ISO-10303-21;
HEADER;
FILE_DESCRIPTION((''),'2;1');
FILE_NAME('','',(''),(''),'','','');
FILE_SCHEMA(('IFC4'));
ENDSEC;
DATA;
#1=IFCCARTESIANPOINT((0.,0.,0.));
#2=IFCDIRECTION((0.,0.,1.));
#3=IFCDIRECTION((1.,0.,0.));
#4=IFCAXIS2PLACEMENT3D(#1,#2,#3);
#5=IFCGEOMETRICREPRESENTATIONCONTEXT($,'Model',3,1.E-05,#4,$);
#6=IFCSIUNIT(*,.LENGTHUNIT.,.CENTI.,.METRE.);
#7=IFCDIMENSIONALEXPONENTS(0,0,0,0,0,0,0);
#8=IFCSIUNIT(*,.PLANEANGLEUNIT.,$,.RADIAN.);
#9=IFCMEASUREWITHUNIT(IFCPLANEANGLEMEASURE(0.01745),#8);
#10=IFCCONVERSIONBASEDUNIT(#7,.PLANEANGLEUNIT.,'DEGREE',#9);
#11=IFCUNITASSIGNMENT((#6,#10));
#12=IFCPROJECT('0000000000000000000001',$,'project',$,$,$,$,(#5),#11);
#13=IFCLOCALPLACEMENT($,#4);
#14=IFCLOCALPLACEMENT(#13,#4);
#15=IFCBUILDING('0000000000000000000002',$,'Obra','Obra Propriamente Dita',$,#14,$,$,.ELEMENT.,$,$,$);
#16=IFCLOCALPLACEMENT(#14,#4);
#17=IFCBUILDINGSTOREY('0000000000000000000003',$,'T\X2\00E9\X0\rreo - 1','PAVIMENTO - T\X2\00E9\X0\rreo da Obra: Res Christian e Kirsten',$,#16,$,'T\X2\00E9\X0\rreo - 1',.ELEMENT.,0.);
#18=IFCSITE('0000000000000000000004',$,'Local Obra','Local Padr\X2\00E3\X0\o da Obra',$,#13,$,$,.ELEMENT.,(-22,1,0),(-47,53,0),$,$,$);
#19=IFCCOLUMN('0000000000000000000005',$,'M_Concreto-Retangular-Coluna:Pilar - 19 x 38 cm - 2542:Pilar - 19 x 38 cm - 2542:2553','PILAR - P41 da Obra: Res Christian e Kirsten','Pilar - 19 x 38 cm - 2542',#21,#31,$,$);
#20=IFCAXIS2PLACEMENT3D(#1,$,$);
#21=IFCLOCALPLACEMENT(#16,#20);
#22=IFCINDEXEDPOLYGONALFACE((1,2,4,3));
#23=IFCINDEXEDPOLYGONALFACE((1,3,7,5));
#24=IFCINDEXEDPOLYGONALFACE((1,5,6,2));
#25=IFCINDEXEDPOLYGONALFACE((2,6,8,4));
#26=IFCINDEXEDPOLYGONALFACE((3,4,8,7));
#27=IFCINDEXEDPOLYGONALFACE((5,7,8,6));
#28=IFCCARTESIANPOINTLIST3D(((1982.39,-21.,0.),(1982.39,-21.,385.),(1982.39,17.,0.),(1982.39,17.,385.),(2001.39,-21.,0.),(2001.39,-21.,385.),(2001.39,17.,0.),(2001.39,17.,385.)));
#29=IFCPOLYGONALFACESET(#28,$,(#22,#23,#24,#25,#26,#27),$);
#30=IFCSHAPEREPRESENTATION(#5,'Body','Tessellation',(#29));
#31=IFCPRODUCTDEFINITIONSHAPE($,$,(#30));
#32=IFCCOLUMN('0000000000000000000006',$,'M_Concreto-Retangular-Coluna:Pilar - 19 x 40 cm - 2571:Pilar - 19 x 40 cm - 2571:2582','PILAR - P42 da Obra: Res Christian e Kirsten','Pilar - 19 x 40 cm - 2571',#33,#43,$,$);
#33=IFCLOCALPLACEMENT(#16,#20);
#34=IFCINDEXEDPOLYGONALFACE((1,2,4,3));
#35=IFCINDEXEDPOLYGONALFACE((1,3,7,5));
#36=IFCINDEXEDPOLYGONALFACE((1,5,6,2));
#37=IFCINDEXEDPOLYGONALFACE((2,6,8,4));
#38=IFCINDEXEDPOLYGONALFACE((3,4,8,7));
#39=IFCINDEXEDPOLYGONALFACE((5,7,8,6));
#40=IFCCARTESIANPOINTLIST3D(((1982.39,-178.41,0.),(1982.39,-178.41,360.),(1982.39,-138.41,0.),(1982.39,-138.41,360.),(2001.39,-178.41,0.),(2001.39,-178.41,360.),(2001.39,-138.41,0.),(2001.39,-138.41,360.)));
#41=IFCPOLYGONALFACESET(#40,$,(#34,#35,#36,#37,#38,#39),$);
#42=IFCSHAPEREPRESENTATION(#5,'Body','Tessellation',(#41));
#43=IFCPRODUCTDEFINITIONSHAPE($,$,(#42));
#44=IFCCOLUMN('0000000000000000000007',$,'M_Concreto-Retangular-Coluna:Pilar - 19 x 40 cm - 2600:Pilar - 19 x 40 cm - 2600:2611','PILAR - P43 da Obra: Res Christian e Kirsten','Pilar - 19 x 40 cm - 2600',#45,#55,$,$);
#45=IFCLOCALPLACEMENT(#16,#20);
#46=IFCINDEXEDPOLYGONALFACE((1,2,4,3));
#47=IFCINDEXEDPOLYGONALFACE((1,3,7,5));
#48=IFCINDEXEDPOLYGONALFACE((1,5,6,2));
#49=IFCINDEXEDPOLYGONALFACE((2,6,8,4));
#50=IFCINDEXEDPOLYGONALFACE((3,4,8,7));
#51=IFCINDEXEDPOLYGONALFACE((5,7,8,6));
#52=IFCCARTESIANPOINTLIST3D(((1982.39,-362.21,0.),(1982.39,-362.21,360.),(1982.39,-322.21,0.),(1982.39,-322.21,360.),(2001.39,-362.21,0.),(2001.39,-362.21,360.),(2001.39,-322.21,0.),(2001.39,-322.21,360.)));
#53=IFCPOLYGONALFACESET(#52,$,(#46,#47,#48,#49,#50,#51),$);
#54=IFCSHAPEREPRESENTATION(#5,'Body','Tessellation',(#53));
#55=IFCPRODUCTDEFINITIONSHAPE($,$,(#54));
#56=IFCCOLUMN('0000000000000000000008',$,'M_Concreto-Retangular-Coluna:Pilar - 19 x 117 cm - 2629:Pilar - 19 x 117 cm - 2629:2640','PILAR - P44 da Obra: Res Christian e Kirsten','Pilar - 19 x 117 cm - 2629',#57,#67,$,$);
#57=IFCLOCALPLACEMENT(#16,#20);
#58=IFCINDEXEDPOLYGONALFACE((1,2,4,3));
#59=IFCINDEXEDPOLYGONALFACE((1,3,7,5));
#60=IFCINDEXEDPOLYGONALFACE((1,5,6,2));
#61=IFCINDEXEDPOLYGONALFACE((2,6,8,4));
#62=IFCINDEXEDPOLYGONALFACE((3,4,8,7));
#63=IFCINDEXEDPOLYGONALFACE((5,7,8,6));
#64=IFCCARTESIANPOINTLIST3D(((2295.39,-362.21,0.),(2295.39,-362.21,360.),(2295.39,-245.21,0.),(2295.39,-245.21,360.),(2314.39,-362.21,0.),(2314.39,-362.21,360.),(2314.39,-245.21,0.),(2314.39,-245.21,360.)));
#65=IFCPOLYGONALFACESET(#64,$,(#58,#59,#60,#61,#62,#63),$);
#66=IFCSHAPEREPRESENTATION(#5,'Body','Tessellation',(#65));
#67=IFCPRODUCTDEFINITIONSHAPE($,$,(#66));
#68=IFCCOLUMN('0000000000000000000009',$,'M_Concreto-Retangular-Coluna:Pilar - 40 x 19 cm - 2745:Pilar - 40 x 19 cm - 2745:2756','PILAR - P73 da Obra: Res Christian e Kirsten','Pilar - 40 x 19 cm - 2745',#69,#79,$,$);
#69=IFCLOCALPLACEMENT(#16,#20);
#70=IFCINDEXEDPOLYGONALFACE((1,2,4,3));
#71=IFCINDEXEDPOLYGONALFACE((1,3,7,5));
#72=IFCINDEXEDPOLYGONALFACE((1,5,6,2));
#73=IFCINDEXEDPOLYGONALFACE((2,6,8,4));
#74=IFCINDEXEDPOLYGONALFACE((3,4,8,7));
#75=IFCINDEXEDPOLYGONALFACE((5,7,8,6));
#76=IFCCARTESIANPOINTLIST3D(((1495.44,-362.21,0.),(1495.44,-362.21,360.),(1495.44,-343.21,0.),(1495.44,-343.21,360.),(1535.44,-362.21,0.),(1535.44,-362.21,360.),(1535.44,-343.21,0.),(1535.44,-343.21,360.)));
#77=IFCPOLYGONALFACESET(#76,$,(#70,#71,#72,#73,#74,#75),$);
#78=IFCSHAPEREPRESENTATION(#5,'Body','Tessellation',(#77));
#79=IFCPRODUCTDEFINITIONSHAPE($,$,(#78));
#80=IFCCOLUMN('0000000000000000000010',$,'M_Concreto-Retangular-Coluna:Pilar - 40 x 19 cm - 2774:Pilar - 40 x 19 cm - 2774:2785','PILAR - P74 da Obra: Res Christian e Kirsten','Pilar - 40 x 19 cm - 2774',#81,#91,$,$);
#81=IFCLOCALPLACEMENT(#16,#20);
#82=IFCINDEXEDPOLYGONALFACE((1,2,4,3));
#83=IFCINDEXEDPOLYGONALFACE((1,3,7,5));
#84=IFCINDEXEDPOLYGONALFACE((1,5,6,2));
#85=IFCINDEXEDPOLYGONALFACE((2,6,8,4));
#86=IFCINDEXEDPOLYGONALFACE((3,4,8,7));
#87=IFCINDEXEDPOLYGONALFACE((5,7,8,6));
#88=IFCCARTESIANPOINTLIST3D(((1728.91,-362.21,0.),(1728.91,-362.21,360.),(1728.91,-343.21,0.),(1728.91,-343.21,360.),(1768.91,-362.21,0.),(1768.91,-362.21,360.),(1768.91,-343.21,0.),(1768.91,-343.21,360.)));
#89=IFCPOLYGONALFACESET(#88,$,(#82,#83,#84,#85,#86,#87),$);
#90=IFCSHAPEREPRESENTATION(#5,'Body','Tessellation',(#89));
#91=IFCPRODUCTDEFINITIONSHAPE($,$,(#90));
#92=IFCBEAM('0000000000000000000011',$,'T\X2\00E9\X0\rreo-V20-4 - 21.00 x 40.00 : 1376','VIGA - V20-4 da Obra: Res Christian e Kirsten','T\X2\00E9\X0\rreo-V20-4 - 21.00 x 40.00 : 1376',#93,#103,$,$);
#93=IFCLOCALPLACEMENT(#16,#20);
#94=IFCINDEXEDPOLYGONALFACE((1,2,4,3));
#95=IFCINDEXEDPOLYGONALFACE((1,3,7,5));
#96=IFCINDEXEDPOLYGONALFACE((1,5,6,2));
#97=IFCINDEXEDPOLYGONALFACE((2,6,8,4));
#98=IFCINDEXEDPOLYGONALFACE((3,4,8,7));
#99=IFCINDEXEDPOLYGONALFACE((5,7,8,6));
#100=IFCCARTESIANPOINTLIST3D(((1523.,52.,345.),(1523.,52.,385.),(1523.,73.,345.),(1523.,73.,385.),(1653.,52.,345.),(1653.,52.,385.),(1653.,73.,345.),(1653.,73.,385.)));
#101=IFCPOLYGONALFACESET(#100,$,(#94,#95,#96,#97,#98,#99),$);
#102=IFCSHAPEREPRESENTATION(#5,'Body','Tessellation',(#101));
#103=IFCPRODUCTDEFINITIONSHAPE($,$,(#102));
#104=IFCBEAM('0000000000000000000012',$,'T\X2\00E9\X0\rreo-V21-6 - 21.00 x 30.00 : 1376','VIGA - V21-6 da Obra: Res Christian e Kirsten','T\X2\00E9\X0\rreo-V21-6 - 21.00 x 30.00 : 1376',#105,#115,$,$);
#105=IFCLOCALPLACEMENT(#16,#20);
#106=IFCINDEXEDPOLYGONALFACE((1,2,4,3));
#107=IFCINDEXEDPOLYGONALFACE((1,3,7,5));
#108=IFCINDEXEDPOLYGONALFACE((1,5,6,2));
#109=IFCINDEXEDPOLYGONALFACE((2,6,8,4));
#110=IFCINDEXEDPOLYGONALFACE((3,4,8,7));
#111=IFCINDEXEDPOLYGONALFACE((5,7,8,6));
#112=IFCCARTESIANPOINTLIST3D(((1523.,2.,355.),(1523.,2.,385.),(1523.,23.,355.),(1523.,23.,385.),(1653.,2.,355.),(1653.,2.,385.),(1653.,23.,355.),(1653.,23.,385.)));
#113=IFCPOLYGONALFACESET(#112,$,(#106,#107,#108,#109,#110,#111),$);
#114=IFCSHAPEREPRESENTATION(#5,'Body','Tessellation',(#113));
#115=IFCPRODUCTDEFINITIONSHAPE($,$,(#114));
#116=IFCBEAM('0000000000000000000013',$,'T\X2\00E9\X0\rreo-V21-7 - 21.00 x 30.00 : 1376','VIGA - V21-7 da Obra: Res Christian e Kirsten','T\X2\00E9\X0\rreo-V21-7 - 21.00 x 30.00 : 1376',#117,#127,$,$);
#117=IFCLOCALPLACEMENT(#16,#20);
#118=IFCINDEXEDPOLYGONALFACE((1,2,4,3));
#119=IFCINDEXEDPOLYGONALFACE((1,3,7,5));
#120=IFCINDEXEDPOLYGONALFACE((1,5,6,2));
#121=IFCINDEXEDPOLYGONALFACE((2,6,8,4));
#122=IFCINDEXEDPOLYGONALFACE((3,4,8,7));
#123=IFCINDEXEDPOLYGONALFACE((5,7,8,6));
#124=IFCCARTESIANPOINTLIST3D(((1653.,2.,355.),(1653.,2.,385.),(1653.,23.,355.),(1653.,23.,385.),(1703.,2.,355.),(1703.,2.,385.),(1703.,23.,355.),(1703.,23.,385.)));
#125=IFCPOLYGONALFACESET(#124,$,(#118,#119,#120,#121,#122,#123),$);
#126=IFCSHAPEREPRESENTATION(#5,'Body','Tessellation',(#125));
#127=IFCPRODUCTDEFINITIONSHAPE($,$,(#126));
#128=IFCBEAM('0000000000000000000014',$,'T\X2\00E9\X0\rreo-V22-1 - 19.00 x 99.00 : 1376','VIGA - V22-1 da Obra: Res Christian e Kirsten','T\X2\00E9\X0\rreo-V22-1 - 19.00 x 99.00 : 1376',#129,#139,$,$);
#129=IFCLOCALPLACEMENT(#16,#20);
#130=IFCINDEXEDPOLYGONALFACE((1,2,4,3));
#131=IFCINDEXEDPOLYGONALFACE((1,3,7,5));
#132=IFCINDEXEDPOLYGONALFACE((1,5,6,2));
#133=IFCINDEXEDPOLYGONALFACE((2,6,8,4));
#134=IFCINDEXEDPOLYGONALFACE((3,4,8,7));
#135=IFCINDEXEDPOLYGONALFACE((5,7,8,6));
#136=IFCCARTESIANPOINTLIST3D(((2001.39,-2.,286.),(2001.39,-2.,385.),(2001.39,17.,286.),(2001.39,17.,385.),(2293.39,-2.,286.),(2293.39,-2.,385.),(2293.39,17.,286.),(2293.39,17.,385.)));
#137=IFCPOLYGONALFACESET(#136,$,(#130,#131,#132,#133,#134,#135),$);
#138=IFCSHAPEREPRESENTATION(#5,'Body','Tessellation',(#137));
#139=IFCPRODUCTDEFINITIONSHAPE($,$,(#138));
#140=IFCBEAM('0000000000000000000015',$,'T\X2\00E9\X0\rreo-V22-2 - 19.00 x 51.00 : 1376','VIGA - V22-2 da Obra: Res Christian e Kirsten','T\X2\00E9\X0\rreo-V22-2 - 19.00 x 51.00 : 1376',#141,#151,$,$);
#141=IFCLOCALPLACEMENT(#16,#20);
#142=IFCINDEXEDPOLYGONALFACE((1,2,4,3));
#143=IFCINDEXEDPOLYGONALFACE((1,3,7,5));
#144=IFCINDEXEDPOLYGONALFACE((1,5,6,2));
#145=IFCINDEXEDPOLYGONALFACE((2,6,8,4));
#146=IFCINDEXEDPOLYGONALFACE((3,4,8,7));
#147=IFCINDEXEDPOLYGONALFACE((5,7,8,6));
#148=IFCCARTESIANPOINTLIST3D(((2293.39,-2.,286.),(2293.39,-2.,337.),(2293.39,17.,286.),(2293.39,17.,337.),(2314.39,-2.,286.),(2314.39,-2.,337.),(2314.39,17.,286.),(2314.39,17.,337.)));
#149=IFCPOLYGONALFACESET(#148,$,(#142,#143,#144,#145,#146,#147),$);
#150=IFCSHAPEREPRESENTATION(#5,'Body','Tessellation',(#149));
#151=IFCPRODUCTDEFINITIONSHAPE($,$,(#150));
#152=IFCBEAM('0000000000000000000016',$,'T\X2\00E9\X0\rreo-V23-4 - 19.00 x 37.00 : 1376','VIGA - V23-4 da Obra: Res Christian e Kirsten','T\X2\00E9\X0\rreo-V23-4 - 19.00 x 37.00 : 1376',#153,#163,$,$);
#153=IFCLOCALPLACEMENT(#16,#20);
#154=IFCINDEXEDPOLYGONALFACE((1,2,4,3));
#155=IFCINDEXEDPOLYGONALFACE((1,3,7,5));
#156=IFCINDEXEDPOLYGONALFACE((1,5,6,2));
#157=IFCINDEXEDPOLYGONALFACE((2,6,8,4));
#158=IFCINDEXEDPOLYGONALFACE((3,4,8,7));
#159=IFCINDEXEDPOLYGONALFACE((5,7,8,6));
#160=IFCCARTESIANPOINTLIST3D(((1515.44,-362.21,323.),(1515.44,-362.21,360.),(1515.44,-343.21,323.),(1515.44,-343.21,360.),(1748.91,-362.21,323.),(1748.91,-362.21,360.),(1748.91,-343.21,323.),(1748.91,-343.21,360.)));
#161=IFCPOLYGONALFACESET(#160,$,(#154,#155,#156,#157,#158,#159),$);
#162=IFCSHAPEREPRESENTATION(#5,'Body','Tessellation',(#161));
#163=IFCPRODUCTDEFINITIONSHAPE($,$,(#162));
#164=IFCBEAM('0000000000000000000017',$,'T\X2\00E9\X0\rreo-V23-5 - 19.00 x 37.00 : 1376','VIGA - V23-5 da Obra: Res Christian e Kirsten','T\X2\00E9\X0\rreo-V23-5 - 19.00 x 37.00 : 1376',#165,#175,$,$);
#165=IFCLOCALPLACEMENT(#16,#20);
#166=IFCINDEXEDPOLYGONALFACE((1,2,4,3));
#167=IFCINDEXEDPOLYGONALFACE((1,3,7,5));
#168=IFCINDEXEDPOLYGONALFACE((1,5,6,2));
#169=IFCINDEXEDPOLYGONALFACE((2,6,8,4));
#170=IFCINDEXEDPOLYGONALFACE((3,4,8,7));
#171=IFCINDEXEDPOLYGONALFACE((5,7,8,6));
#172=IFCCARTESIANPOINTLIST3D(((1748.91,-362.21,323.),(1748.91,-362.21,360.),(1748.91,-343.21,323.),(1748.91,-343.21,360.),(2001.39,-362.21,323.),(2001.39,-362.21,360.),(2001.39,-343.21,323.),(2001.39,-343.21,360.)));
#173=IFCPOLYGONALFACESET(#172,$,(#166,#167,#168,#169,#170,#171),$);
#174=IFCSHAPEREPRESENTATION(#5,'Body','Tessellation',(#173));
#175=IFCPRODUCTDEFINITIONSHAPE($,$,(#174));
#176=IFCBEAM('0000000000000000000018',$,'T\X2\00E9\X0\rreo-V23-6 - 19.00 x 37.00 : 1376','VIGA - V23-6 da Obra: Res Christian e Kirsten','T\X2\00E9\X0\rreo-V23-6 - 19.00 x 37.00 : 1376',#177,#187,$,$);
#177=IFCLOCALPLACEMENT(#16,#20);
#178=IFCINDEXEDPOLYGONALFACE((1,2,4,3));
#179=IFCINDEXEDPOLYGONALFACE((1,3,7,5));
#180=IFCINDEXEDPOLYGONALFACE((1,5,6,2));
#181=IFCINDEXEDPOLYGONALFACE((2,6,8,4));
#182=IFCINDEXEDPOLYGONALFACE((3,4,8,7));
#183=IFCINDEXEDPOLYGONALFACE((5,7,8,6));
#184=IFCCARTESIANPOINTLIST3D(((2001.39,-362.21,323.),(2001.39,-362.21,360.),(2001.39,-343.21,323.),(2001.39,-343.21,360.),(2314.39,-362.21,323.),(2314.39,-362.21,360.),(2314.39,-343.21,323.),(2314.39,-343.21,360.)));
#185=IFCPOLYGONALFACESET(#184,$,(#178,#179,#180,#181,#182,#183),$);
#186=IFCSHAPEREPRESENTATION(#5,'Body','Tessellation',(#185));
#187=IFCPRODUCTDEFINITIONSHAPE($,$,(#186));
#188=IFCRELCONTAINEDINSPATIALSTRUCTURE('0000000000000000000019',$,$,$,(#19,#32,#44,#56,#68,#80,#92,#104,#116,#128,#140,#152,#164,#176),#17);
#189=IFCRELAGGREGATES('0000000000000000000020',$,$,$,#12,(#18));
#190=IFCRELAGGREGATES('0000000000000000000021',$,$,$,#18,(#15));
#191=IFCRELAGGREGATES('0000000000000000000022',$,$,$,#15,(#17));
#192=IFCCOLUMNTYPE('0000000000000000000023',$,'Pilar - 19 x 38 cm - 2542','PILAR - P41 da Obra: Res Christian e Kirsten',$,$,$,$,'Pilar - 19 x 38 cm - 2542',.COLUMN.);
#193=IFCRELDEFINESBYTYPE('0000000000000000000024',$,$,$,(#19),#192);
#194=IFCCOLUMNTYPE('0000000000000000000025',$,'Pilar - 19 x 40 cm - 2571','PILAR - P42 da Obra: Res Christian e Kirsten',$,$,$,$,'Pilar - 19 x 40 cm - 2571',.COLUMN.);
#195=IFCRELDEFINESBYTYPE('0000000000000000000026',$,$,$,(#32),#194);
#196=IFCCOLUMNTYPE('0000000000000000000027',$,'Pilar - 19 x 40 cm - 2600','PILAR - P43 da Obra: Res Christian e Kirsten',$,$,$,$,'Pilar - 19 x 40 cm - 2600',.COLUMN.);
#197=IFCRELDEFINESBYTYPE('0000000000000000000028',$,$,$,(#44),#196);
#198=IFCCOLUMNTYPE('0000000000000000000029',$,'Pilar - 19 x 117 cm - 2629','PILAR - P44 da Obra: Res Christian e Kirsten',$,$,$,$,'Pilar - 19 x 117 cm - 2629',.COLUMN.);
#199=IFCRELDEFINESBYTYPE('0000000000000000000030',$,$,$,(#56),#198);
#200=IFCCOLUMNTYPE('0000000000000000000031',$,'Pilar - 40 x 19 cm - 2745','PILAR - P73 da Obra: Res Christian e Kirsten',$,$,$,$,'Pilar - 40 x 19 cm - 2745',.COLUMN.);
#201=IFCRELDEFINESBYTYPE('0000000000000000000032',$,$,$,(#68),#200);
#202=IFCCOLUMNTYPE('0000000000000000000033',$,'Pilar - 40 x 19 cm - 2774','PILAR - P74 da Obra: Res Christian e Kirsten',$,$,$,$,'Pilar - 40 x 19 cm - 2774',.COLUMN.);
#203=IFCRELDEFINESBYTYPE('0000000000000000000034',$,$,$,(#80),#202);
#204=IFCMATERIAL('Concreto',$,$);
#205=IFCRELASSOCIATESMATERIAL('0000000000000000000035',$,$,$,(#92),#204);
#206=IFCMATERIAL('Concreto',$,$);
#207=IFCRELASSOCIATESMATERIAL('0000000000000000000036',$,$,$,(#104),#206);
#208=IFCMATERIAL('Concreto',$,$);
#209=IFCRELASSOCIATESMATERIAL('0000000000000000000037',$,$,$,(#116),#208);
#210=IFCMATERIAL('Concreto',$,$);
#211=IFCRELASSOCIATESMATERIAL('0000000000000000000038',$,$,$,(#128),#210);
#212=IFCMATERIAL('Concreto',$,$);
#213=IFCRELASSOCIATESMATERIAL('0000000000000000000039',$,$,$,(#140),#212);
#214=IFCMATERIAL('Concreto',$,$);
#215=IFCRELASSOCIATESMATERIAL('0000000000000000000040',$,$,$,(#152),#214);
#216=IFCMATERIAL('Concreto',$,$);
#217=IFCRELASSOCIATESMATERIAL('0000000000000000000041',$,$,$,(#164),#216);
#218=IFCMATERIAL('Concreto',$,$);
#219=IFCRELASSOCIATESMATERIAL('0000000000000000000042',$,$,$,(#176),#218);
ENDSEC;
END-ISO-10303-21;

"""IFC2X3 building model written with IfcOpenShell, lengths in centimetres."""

from ifc_helpers import new_model, entity, si_unit, converted_unit, frame, origin, origin_with_axes, origin_2d_with_axis, place, context, project, spatial, polyline, rectangle, outline, extrude, source, transform, mapped, material, type_object, type_shapes, element, save


model = new_model("IFC2X3")

# Units and contexts
model_context = context("Model", 3, precision=1e-05, world=origin_with_axes())
ifc_project = project(units=[si_unit("LENGTHUNIT", "METRE", prefix="CENTI"), converted_unit("PLANEANGLEUNIT", "DEGREE", entity("IfcPlaneAngleMeasure", 0.01745), si_unit("PLANEANGLEUNIT", "RADIAN"), dimensions=[0, 0, 0, 0, 0, 0, 0])], contexts=[model_context])

# Site, building, storey
site_placement = place(None, origin_with_axes())
site = spatial("IfcSite", under=ifc_project, at=site_placement, Name="Local Obra", Description="Local Padrão da Obra", CompositionType="ELEMENT", RefLatitude=(-22, 1, 0), RefLongitude=(-47, 53, 0))
building_placement = place(site_placement, origin_with_axes())
building = spatial("IfcBuilding", under=site, at=building_placement, Name="Obra", Description="Obra Propriamente Dita", CompositionType="ELEMENT")
storey_placement = place(building_placement, origin_with_axes())
storey = spatial("IfcBuildingStorey", under=building, at=storey_placement, Name="Térreo - 1", Description="PAVIMENTO - Térreo da Obra: Res Christian e Kirsten", LongName="Térreo - 1", CompositionType="ELEMENT", Elevation=0.0)

# Columns
column_type_1 = type_object("IfcColumnType", Name="Pilar - 19 x 38 cm - 2542", Description="PILAR - P41 da Obra: Res Christian e Kirsten", ElementType="Pilar - 19 x 38 cm - 2542", PredefinedType="COLUMN")
shared_shape_1 = source(origin(), model_context, "Body", "SweptSolid", [
    extrude(rectangle(XDim=19.0, YDim=38.0, at=origin_2d_with_axis()), origin(), (0.0, 0.0, 1.0), 385.0),
])
type_shapes(column_type_1, [shared_shape_1])
column_1_placement = place(storey_placement, frame((1991.89, -2.0, 0.0), z_axis=(0.0, 0.0, 1.0), x_axis=(1.0, 0.0, 0.0)))
element("IfcColumn", 1, at=column_1_placement, inside=storey, type_object=column_type_1, Name="M_Concreto-Retangular-Coluna:Pilar - 19 x 38 cm - 2542:Pilar - 19 x 38 cm - 2542:2553", Description="PILAR - P41 da Obra: Res Christian e Kirsten", ObjectType="Pilar - 19 x 38 cm - 2542", context=model_context, shape_type="MappedRepresentation", body=[
    mapped(shared_shape_1, transform((0.0, 0.0, 0.0), scale=1.0)),
])
column_type_2 = type_object("IfcColumnType", Name="Pilar - 19 x 40 cm - 2571", Description="PILAR - P42 da Obra: Res Christian e Kirsten", ElementType="Pilar - 19 x 40 cm - 2571", PredefinedType="COLUMN")
shared_shape_2 = source(origin(), model_context, "Body", "SweptSolid", [
    extrude(rectangle(XDim=19.0, YDim=40.0, at=origin_2d_with_axis()), origin(), (0.0, 0.0, 1.0), 360.0),
])
type_shapes(column_type_2, [shared_shape_2])
column_2_placement = place(storey_placement, frame((1991.89, -158.41, 0.0), z_axis=(0.0, 0.0, 1.0), x_axis=(1.0, 0.0, 0.0)))
element("IfcColumn", 2, at=column_2_placement, inside=storey, type_object=column_type_2, Name="M_Concreto-Retangular-Coluna:Pilar - 19 x 40 cm - 2571:Pilar - 19 x 40 cm - 2571:2582", Description="PILAR - P42 da Obra: Res Christian e Kirsten", ObjectType="Pilar - 19 x 40 cm - 2571", context=model_context, shape_type="MappedRepresentation", body=[
    mapped(shared_shape_2, transform((0.0, 0.0, 0.0), scale=1.0)),
])
column_type_3 = type_object("IfcColumnType", Name="Pilar - 19 x 40 cm - 2600", Description="PILAR - P43 da Obra: Res Christian e Kirsten", ElementType="Pilar - 19 x 40 cm - 2600", PredefinedType="COLUMN")
shared_shape_3 = source(origin(), model_context, "Body", "SweptSolid", [
    extrude(rectangle(XDim=19.0, YDim=40.0, at=origin_2d_with_axis()), origin(), (0.0, 0.0, 1.0), 360.0),
])
type_shapes(column_type_3, [shared_shape_3])
column_3_placement = place(storey_placement, frame((1991.89, -342.21, 0.0), z_axis=(0.0, 0.0, 1.0), x_axis=(1.0, 0.0, 0.0)))
element("IfcColumn", 3, at=column_3_placement, inside=storey, type_object=column_type_3, Name="M_Concreto-Retangular-Coluna:Pilar - 19 x 40 cm - 2600:Pilar - 19 x 40 cm - 2600:2611", Description="PILAR - P43 da Obra: Res Christian e Kirsten", ObjectType="Pilar - 19 x 40 cm - 2600", context=model_context, shape_type="MappedRepresentation", body=[
    mapped(shared_shape_3, transform((0.0, 0.0, 0.0), scale=1.0)),
])
column_type_4 = type_object("IfcColumnType", Name="Pilar - 19 x 117 cm - 2629", Description="PILAR - P44 da Obra: Res Christian e Kirsten", ElementType="Pilar - 19 x 117 cm - 2629", PredefinedType="COLUMN")
shared_shape_4 = source(origin(), model_context, "Body", "SweptSolid", [
    extrude(rectangle(XDim=19.0, YDim=117.0, at=origin_2d_with_axis()), origin(), (0.0, 0.0, 1.0), 360.0),
])
type_shapes(column_type_4, [shared_shape_4])
column_4_placement = place(storey_placement, frame((2304.89, -303.71, 0.0), z_axis=(0.0, 0.0, 1.0), x_axis=(1.0, 0.0, 0.0)))
element("IfcColumn", 4, at=column_4_placement, inside=storey, type_object=column_type_4, Name="M_Concreto-Retangular-Coluna:Pilar - 19 x 117 cm - 2629:Pilar - 19 x 117 cm - 2629:2640", Description="PILAR - P44 da Obra: Res Christian e Kirsten", ObjectType="Pilar - 19 x 117 cm - 2629", context=model_context, shape_type="MappedRepresentation", body=[
    mapped(shared_shape_4, transform((0.0, 0.0, 0.0), scale=1.0)),
])
column_type_5 = type_object("IfcColumnType", Name="Pilar - 40 x 19 cm - 2745", Description="PILAR - P73 da Obra: Res Christian e Kirsten", ElementType="Pilar - 40 x 19 cm - 2745", PredefinedType="COLUMN")
shared_shape_5 = source(origin(), model_context, "Body", "SweptSolid", [
    extrude(rectangle(XDim=40.0, YDim=19.0, at=origin_2d_with_axis()), origin(), (0.0, 0.0, 1.0), 360.0),
])
type_shapes(column_type_5, [shared_shape_5])
column_5_placement = place(storey_placement, frame((1515.44, -352.71, 0.0), z_axis=(0.0, 0.0, 1.0), x_axis=(1.0, 0.0, 0.0)))
element("IfcColumn", 5, at=column_5_placement, inside=storey, type_object=column_type_5, Name="M_Concreto-Retangular-Coluna:Pilar - 40 x 19 cm - 2745:Pilar - 40 x 19 cm - 2745:2756", Description="PILAR - P73 da Obra: Res Christian e Kirsten", ObjectType="Pilar - 40 x 19 cm - 2745", context=model_context, shape_type="MappedRepresentation", body=[
    mapped(shared_shape_5, transform((0.0, 0.0, 0.0), scale=1.0)),
])
column_type_6 = type_object("IfcColumnType", Name="Pilar - 40 x 19 cm - 2774", Description="PILAR - P74 da Obra: Res Christian e Kirsten", ElementType="Pilar - 40 x 19 cm - 2774", PredefinedType="COLUMN")
shared_shape_6 = source(origin(), model_context, "Body", "SweptSolid", [
    extrude(rectangle(XDim=40.0, YDim=19.0, at=origin_2d_with_axis()), origin(), (0.0, 0.0, 1.0), 360.0),
])
type_shapes(column_type_6, [shared_shape_6])
column_6_placement = place(storey_placement, frame((1748.91, -352.71, 0.0), z_axis=(0.0, 0.0, 1.0), x_axis=(1.0, 0.0, 0.0)))
element("IfcColumn", 6, at=column_6_placement, inside=storey, type_object=column_type_6, Name="M_Concreto-Retangular-Coluna:Pilar - 40 x 19 cm - 2774:Pilar - 40 x 19 cm - 2774:2785", Description="PILAR - P74 da Obra: Res Christian e Kirsten", ObjectType="Pilar - 40 x 19 cm - 2774", context=model_context, shape_type="MappedRepresentation", body=[
    mapped(shared_shape_6, transform((0.0, 0.0, 0.0), scale=1.0)),
])

# Beams
ifc_material_1 = material(Name="Concreto")
beam_1_placement = place(storey_placement, frame((1523.0, 52.0, 385.0), z_axis=(1.0, 0.0, 0.0), x_axis=(0.0, -1.0, 0.0)))
element("IfcBeam", 7, at=beam_1_placement, inside=storey, material=ifc_material_1, Name="Térreo-V20-4 - 21.00 x 40.00 : 1376", Description="VIGA - V20-4 da Obra: Res Christian e Kirsten", ObjectType="Térreo-V20-4 - 21.00 x 40.00 : 1376", context=model_context, shape_type="SweptSolid", body=[
    extrude(outline(polyline([(-21.0, 0.0), (0.0, 0.0), (0.0, 40.0), (-21.0, 40.0), (-21.0, 0.0)])), origin_with_axes(), (0.0, 0.0, 1.0), 130.0),
])
ifc_material_2 = material(Name="Concreto")
beam_2_placement = place(storey_placement, frame((1523.0, 2.0, 385.0), z_axis=(1.0, 0.0, 0.0), x_axis=(0.0, -1.0, 0.0)))
element("IfcBeam", 8, at=beam_2_placement, inside=storey, material=ifc_material_2, Name="Térreo-V21-6 - 21.00 x 30.00 : 1376", Description="VIGA - V21-6 da Obra: Res Christian e Kirsten", ObjectType="Térreo-V21-6 - 21.00 x 30.00 : 1376", context=model_context, shape_type="SweptSolid", body=[
    extrude(outline(polyline([(-21.0, 0.0), (0.0, 0.0), (0.0, 30.0), (-21.0, 30.0), (-21.0, 0.0)])), origin_with_axes(), (0.0, 0.0, 1.0), 130.0),
])
ifc_material_3 = material(Name="Concreto")
beam_3_placement = place(storey_placement, frame((1653.0, 2.0, 385.0), z_axis=(1.0, 0.0, 0.0), x_axis=(0.0, -1.0, 0.0)))
element("IfcBeam", 9, at=beam_3_placement, inside=storey, material=ifc_material_3, Name="Térreo-V21-7 - 21.00 x 30.00 : 1376", Description="VIGA - V21-7 da Obra: Res Christian e Kirsten", ObjectType="Térreo-V21-7 - 21.00 x 30.00 : 1376", context=model_context, shape_type="SweptSolid", body=[
    extrude(outline(polyline([(-21.0, 0.0), (0.0, 0.0), (0.0, 30.0), (-21.0, 30.0), (-21.0, 0.0)])), origin_with_axes(), (0.0, 0.0, 1.0), 50.0),
])
ifc_material_4 = material(Name="Concreto")
beam_4_placement = place(storey_placement, frame((2001.39, -2.0, 385.0), z_axis=(1.0, 0.0, 0.0), x_axis=(0.0, -1.0, 0.0)))
element("IfcBeam", 10, at=beam_4_placement, inside=storey, material=ifc_material_4, Name="Térreo-V22-1 - 19.00 x 99.00 : 1376", Description="VIGA - V22-1 da Obra: Res Christian e Kirsten", ObjectType="Térreo-V22-1 - 19.00 x 99.00 : 1376", context=model_context, shape_type="SweptSolid", body=[
    extrude(outline(polyline([(-19.0, 0.0), (0.0, 0.0), (0.0, 99.0), (-19.0, 99.0), (-19.0, 0.0)])), origin_with_axes(), (0.0, 0.0, 1.0), 292.0),
])
ifc_material_5 = material(Name="Concreto")
beam_5_placement = place(storey_placement, frame((2293.39, -2.0, 337.0), z_axis=(1.0, 0.0, 0.0), x_axis=(0.0, -1.0, 0.0)))
element("IfcBeam", 11, at=beam_5_placement, inside=storey, material=ifc_material_5, Name="Térreo-V22-2 - 19.00 x 51.00 : 1376", Description="VIGA - V22-2 da Obra: Res Christian e Kirsten", ObjectType="Térreo-V22-2 - 19.00 x 51.00 : 1376", context=model_context, shape_type="SweptSolid", body=[
    extrude(outline(polyline([(-19.0, 0.0), (0.0, 0.0), (0.0, 51.0), (-19.0, 51.0), (-19.0, 0.0)])), origin_with_axes(), (0.0, 0.0, 1.0), 21.0),
])
ifc_material_6 = material(Name="Concreto")
beam_6_placement = place(storey_placement, frame((1515.44, -362.21, 360.0), z_axis=(1.0, 0.0, 0.0), x_axis=(0.0, -1.0, 0.0)))
element("IfcBeam", 12, at=beam_6_placement, inside=storey, material=ifc_material_6, Name="Térreo-V23-4 - 19.00 x 37.00 : 1376", Description="VIGA - V23-4 da Obra: Res Christian e Kirsten", ObjectType="Térreo-V23-4 - 19.00 x 37.00 : 1376", context=model_context, shape_type="SweptSolid", body=[
    extrude(outline(polyline([(-19.0, 0.0), (0.0, 0.0), (0.0, 37.0), (-19.0, 37.0), (-19.0, 0.0)])), origin_with_axes(), (0.0, 0.0, 1.0), 233.48),
])
ifc_material_7 = material(Name="Concreto")
beam_7_placement = place(storey_placement, frame((1748.91, -362.21, 360.0), z_axis=(1.0, 0.0, 0.0), x_axis=(0.0, -1.0, 0.0)))
element("IfcBeam", 13, at=beam_7_placement, inside=storey, material=ifc_material_7, Name="Térreo-V23-5 - 19.00 x 37.00 : 1376", Description="VIGA - V23-5 da Obra: Res Christian e Kirsten", ObjectType="Térreo-V23-5 - 19.00 x 37.00 : 1376", context=model_context, shape_type="SweptSolid", body=[
    extrude(outline(polyline([(-19.0, 0.0), (0.0, 0.0), (0.0, 37.0), (-19.0, 37.0), (-19.0, 0.0)])), origin_with_axes(), (0.0, 0.0, 1.0), 252.48),
])
ifc_material_8 = material(Name="Concreto")
beam_8_placement = place(storey_placement, frame((2001.39, -362.21, 360.0), z_axis=(1.0, 0.0, 0.0), x_axis=(0.0, -1.0, 0.0)))
element("IfcBeam", 14, at=beam_8_placement, inside=storey, material=ifc_material_8, Name="Térreo-V23-6 - 19.00 x 37.00 : 1376", Description="VIGA - V23-6 da Obra: Res Christian e Kirsten", ObjectType="Térreo-V23-6 - 19.00 x 37.00 : 1376", context=model_context, shape_type="SweptSolid", body=[
    extrude(outline(polyline([(-19.0, 0.0), (0.0, 0.0), (0.0, 37.0), (-19.0, 37.0), (-19.0, 0.0)])), origin_with_axes(), (0.0, 0.0, 1.0), 313.0),
])

save(model, "model.ifc")
